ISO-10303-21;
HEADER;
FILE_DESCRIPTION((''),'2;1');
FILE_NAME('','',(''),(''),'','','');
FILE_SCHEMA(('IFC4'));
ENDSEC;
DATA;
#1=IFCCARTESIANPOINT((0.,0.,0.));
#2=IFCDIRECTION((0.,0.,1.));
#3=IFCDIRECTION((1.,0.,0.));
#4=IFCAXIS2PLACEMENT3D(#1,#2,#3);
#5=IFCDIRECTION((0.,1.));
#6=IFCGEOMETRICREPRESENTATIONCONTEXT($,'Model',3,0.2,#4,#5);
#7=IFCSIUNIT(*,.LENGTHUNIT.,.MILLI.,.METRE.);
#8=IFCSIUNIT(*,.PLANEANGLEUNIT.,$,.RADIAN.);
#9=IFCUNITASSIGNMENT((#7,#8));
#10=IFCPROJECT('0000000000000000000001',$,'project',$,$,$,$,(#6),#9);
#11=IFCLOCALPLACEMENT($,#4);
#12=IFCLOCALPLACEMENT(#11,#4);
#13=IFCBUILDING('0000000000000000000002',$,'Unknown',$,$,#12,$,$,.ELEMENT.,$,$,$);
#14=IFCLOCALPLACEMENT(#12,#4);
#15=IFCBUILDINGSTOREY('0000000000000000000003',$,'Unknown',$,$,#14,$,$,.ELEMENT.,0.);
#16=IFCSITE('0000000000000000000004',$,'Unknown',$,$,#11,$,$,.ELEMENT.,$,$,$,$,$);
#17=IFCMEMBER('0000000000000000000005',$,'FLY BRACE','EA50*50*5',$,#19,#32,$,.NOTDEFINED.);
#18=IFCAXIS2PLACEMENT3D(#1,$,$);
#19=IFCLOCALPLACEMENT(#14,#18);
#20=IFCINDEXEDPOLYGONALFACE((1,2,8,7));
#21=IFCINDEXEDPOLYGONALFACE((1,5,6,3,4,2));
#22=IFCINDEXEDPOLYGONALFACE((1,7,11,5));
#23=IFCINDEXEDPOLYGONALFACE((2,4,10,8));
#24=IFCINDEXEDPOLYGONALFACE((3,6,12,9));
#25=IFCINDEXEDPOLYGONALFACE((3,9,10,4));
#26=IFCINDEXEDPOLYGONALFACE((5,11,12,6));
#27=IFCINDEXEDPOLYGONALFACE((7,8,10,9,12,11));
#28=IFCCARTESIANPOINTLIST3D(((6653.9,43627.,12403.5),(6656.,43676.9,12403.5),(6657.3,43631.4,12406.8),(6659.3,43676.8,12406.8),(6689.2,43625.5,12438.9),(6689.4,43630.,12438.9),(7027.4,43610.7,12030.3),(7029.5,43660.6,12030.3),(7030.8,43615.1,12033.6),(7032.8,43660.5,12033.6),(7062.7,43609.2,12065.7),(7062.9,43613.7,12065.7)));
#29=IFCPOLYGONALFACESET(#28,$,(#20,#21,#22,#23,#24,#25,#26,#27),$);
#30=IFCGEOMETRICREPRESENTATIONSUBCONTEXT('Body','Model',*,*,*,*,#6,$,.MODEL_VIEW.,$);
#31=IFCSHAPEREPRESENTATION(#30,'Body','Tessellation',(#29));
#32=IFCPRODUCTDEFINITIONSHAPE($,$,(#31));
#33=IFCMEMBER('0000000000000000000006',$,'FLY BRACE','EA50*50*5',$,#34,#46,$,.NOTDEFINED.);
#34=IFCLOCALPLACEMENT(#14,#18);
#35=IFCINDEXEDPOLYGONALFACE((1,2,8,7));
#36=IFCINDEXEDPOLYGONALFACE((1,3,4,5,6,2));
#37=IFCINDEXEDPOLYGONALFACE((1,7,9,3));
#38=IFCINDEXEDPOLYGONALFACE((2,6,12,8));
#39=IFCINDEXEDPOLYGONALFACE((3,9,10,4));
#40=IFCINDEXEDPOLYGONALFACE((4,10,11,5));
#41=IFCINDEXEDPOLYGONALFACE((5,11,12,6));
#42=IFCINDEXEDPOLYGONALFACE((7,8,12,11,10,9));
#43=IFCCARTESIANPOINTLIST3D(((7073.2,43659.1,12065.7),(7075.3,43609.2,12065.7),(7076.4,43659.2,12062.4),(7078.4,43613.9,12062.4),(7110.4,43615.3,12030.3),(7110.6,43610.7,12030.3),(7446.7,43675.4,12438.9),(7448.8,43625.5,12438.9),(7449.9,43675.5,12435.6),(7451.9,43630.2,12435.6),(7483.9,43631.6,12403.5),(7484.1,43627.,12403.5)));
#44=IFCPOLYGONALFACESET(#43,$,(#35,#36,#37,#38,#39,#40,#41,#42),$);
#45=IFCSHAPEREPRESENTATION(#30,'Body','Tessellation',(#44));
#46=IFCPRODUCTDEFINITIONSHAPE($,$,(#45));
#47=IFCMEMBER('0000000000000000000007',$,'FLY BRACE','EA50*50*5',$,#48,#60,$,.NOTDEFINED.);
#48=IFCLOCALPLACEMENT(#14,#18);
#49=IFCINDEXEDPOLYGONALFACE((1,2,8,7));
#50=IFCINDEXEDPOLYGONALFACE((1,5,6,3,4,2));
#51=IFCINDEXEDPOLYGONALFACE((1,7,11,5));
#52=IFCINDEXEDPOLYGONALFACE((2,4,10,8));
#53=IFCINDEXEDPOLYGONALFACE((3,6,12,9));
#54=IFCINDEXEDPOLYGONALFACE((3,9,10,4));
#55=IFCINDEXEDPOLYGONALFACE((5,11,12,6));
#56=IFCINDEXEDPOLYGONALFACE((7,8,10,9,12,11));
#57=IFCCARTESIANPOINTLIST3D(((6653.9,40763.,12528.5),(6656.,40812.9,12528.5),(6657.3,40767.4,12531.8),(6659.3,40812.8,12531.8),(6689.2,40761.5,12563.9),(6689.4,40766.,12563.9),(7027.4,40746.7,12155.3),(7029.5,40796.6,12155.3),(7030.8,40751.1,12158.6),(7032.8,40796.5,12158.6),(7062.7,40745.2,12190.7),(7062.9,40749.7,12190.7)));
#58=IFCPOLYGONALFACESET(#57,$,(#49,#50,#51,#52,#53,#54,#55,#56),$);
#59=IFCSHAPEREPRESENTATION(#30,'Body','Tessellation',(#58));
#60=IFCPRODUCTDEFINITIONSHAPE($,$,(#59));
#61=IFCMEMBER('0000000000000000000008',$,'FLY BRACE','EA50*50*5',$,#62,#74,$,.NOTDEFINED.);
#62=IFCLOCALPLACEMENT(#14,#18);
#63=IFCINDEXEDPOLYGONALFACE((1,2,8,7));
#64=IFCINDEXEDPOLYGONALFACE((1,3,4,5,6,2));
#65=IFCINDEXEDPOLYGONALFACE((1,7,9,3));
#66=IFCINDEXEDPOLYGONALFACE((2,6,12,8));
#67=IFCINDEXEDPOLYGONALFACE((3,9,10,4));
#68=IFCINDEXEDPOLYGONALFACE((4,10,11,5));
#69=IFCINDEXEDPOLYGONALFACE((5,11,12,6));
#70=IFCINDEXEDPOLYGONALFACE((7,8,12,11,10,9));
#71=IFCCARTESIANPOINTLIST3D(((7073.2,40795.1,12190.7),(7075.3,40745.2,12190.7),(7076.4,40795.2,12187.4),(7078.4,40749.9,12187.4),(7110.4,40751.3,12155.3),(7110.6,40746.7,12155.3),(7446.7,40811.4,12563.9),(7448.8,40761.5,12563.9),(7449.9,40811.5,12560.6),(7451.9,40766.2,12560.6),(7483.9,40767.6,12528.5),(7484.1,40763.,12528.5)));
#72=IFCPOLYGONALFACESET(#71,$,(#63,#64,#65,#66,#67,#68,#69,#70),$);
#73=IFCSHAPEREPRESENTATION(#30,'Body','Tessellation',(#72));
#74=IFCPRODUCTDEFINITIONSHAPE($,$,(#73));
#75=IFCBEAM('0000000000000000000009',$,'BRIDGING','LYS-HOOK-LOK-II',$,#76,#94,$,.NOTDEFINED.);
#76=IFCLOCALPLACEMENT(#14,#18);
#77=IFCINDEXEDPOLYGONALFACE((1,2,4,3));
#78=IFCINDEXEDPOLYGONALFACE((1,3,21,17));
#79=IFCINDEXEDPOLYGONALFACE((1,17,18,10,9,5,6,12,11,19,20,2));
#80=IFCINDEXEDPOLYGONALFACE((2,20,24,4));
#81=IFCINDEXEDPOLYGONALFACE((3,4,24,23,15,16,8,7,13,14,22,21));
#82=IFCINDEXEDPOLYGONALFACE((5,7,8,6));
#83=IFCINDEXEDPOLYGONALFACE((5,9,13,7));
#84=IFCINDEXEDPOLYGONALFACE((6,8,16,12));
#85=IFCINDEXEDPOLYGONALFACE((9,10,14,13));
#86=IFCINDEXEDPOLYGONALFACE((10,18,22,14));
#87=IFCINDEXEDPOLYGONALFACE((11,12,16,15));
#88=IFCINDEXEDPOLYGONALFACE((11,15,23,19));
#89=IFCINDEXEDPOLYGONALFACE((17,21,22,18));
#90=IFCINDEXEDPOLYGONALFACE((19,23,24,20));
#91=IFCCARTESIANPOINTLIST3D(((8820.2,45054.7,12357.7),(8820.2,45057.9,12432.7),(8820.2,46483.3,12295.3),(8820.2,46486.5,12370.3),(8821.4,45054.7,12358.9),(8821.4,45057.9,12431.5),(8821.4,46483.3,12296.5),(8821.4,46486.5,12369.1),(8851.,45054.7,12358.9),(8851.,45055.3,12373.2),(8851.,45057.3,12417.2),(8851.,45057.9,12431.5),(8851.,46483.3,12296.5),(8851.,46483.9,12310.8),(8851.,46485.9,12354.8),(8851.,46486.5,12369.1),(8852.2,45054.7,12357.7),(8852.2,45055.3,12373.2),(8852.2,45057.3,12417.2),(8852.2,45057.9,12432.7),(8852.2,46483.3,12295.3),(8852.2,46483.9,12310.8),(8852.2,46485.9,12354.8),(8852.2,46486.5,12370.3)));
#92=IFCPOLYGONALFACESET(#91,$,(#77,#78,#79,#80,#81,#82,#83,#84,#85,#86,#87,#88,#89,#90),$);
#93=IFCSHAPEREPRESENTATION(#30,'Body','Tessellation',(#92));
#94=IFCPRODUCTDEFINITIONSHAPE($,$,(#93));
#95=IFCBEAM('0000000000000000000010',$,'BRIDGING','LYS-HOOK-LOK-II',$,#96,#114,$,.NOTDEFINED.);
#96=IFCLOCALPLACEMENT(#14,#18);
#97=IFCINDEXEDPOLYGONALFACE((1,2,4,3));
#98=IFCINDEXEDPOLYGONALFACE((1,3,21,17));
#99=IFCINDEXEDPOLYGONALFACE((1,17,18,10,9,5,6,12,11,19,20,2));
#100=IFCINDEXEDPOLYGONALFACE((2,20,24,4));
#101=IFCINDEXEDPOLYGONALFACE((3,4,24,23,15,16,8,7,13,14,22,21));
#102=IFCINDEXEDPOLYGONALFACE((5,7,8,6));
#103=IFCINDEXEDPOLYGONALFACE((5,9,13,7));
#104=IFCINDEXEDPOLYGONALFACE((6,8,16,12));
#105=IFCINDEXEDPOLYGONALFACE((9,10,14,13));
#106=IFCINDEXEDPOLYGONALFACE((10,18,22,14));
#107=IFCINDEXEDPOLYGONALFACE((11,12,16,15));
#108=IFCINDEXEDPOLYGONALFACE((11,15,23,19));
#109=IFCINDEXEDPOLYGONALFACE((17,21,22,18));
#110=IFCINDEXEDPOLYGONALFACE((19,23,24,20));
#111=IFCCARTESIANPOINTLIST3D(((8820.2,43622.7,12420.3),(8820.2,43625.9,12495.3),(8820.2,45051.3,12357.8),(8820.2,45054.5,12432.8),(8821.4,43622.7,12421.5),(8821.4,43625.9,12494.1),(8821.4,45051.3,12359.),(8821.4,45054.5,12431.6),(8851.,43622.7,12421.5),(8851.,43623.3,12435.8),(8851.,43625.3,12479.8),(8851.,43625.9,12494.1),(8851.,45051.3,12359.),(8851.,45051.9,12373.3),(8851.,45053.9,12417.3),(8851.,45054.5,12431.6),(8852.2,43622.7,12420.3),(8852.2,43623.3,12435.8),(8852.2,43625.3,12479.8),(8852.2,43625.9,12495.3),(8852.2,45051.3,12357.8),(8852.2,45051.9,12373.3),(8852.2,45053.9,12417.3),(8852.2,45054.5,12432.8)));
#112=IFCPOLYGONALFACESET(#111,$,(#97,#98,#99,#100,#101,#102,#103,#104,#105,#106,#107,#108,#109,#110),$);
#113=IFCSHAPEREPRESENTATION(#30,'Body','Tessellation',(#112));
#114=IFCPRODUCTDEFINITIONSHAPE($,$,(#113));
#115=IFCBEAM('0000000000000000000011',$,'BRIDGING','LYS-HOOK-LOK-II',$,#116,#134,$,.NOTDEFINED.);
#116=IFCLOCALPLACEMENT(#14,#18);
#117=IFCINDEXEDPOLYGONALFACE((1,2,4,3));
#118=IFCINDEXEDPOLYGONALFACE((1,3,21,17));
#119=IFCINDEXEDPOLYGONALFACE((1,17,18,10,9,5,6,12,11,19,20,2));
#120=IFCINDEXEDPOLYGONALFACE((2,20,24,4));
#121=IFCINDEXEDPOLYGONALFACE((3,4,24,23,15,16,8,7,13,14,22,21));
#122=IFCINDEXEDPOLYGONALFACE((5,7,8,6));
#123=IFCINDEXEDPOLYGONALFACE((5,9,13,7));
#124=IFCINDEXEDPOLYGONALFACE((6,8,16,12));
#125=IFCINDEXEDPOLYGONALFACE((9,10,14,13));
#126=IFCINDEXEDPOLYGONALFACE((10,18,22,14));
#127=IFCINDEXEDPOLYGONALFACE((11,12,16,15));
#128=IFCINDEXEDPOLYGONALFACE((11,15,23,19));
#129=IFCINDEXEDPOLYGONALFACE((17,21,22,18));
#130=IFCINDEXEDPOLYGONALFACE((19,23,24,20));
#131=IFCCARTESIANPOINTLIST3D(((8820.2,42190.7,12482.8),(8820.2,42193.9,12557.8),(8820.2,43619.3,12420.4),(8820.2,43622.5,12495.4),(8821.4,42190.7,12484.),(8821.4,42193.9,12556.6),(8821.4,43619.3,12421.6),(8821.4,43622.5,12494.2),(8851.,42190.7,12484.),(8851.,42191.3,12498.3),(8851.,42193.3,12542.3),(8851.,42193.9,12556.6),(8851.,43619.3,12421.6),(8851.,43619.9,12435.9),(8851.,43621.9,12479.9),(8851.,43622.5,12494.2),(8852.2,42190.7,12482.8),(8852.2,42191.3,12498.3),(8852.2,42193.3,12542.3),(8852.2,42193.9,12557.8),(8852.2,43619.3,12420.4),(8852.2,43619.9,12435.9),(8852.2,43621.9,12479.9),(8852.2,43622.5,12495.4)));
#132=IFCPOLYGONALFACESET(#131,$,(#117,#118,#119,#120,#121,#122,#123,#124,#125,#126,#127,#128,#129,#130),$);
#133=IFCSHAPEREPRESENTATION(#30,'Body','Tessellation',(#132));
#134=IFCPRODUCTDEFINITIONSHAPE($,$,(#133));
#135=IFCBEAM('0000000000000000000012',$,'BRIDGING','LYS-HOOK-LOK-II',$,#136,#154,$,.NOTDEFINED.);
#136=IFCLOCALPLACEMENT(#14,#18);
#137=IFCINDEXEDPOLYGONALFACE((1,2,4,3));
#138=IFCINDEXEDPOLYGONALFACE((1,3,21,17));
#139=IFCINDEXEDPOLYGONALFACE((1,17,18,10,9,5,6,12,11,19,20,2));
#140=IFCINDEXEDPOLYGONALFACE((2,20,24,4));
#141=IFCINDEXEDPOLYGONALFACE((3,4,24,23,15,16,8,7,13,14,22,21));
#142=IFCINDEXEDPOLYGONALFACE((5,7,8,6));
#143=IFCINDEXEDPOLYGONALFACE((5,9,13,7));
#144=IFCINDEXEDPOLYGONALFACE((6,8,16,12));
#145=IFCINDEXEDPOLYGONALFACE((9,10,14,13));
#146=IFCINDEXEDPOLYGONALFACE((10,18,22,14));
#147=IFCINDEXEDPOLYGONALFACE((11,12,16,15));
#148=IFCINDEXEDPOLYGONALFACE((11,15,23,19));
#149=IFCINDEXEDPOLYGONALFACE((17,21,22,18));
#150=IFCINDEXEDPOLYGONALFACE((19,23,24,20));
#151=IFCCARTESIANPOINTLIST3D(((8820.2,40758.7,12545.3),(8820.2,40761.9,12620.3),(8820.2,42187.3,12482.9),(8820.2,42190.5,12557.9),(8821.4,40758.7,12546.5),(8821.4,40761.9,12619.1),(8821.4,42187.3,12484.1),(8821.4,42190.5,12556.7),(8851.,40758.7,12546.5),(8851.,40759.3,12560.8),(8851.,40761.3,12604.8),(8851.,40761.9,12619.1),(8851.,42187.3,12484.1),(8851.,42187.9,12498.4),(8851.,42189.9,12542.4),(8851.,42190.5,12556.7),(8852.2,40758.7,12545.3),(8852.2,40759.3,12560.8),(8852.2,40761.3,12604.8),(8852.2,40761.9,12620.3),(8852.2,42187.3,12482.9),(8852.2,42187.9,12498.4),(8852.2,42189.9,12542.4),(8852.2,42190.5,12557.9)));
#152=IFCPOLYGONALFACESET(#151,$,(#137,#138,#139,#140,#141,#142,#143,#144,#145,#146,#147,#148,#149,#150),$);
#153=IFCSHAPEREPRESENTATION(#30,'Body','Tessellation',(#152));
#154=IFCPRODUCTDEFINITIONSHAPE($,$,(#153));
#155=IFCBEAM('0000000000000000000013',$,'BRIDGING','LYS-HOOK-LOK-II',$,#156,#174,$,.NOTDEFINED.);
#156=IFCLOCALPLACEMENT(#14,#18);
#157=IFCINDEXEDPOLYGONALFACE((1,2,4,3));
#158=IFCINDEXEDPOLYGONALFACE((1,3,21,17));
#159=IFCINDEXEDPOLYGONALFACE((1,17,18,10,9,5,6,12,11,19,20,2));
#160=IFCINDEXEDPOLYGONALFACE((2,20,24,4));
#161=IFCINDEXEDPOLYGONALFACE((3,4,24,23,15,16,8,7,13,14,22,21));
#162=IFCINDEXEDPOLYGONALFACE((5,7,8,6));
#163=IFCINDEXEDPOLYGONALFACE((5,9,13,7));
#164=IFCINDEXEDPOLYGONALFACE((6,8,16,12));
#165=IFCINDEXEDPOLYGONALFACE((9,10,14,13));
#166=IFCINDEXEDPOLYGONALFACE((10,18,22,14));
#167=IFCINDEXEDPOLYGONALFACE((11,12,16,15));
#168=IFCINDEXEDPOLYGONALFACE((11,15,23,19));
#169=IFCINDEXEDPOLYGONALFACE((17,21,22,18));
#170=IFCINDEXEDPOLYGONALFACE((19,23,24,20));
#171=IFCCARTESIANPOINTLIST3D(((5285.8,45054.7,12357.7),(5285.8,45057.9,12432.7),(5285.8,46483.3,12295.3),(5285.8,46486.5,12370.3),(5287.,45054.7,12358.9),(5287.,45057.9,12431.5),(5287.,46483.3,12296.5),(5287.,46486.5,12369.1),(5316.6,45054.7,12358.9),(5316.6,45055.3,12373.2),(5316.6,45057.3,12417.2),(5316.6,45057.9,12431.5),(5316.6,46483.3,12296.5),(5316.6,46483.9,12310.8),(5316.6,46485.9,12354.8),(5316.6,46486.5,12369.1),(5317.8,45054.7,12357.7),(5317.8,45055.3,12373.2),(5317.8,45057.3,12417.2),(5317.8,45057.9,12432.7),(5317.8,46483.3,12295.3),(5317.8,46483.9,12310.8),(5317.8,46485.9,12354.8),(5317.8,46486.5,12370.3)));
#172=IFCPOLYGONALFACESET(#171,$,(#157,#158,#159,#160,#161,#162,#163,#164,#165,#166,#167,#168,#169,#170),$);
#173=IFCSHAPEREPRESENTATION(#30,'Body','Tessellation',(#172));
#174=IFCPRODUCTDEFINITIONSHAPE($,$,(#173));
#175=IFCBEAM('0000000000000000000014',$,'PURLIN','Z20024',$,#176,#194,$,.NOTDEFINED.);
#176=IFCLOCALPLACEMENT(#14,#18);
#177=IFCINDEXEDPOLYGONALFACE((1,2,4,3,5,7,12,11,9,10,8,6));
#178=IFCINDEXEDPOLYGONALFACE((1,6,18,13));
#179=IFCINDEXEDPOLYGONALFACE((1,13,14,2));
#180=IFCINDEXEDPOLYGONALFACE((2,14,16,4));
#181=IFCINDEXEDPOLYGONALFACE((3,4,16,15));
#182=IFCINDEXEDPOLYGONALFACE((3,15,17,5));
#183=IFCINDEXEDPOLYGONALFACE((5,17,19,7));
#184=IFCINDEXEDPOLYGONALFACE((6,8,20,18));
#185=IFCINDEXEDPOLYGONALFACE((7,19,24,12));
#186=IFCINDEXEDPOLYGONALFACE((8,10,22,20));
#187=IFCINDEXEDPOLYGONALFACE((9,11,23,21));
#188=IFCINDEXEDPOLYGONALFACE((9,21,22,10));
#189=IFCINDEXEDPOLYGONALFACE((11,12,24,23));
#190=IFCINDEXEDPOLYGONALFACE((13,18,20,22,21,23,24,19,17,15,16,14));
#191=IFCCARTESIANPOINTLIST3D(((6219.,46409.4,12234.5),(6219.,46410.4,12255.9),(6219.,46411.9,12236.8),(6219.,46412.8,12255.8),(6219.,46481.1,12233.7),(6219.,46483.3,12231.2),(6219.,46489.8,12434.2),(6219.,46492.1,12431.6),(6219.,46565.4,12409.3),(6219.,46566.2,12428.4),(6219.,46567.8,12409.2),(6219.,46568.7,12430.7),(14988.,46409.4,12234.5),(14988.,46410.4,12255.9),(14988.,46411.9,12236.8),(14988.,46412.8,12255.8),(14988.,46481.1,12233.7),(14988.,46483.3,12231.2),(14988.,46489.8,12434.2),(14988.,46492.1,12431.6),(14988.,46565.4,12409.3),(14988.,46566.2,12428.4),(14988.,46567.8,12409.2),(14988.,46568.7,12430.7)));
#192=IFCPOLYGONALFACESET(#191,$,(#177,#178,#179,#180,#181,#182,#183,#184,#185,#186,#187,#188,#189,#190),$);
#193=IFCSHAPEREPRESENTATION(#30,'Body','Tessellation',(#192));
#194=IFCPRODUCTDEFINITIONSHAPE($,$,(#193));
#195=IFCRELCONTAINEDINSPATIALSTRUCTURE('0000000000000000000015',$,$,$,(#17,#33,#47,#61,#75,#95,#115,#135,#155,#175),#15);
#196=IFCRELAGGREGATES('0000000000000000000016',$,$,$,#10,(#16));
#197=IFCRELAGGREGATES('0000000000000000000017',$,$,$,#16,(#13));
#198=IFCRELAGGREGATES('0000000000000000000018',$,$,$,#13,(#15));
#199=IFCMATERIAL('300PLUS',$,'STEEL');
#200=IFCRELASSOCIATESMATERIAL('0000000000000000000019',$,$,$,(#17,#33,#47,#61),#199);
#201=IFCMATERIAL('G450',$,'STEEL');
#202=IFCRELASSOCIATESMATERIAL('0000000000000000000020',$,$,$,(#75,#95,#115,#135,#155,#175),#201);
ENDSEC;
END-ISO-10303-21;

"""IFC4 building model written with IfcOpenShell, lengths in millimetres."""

from ifc_helpers import new_model, si_unit, direction, frame, origin_with_axes, place, context, subcontext, project, spatial, line, indexed_curve, outline, extrude, material, element, save


model = new_model("IFC4")

# Units and contexts
model_context = context("Model", 3, precision=0.2, world=origin_with_axes(), true_north=direction((0.0, 1.0)))
body_context = subcontext(model_context, "Body", "Model", "MODEL_VIEW")
ifc_project = project(units=[si_unit("LENGTHUNIT", "METRE", prefix="MILLI"), si_unit("PLANEANGLEUNIT", "RADIAN")], contexts=[model_context])

# Site, building, storey
site_placement = place(None, origin_with_axes())
site = spatial("IfcSite", under=ifc_project, at=site_placement, Name="Unknown", CompositionType="ELEMENT")
building_placement = place(site_placement, origin_with_axes())
building = spatial("IfcBuilding", under=site, at=building_placement, Name="Unknown", CompositionType="ELEMENT")
storey_placement = place(building_placement, origin_with_axes())
storey = spatial("IfcBuildingStorey", under=building, at=storey_placement, Name="Unknown", CompositionType="ELEMENT", Elevation=0.0)

# Members
ifc_material_1 = material(Name="300PLUS", Category="STEEL")
for number, where, z_axis, x_axis, name in (
    (1, (7046.1, 43634.9, 12048.0), (0.0436, 0.999049, 0.0), (-0.707054, 0.030857, 0.706486), "FLY BRACE"),
    (2, (7091.9, 43634.9, 12048.0), (-0.0436, 0.999049, 0.0), (0.707054, 0.030857, 0.706486), "FLY BRACE"),
    (3, (7046.1, 40770.9, 12173.0), (0.0436, 0.999049, 0.0), (-0.707054, 0.030857, 0.706486), "FLY BRACE"),
    (4, (7091.9, 40770.9, 12173.0), (-0.0436, 0.999049, 0.0), (0.707054, 0.030857, 0.706486), "FLY BRACE"),
):
    element("IfcMember", number, at=place(storey_placement, frame(where, z_axis=z_axis, x_axis=x_axis)), inside=storey, material=ifc_material_1, Name=name, Description="EA50*50*5", PredefinedType="NOTDEFINED", context=body_context, shape_type="SolidModel", body=[
        extrude(outline(indexed_curve([(-25.0, -25.0), (25.0, -25.0), (25.0, -20.4), (-20.4, -20.4), (-20.4, 25.0), (-25.0, 25.0)], segments=[line(1, 2, 3, 4, 5, 6, 1)])), frame((0.0, 0.0, 0.0), z_axis=(-1.0, 0.0, 0.0), x_axis=(0.0, 0.0, 1.0)), (0.0, 0.0, -1.0), 528.2),
    ])

# Beams
ifc_material_2 = material(Name="G450", Category="STEEL")
beam_1_placement = place(storey_placement, frame((8836.2, 45056.3, 12395.2), z_axis=(1.0, 0.0, 0.0), x_axis=(0.0, 0.999047, -0.043638)))
element("IfcBeam", 5, at=beam_1_placement, inside=storey, material=ifc_material_2, Name="BRIDGING", Description="LYS-HOOK-LOK-II", PredefinedType="NOTDEFINED", context=body_context, shape_type="SolidModel", body=[
    extrude(outline(indexed_curve([(16.0, -37.5), (16.0, -22.0), (14.8, -22.0), (14.8, -36.3), (-14.8, -36.3), (-14.8, 36.3), (14.8, 36.3), (14.8, 22.0), (16.0, 22.0), (16.0, 37.5), (-16.0, 37.5), (-16.0, -37.5)], segments=[line(1, 2, 3, 4, 5, 6, 7, 8, 9, 10, 11, 12, 1)])), frame((0.0, 0.0, 0.0), z_axis=(-1.0, 0.0, 0.0), x_axis=(0.0, 0.0, 1.0)), (0.0, 0.0, -1.0), 1430.0),
])
beam_2_placement = place(storey_placement, frame((8836.2, 43624.3, 12457.8), z_axis=(1.0, 0.0, 0.0), x_axis=(0.0, 0.999044, -0.043707)))
element("IfcBeam", 6, at=beam_2_placement, inside=storey, material=ifc_material_2, Name="BRIDGING", Description="LYS-HOOK-LOK-II", PredefinedType="NOTDEFINED", context=body_context, shape_type="SolidModel", body=[
    extrude(outline(indexed_curve([(16.0, -37.5), (16.0, -22.0), (14.8, -22.0), (14.8, -36.3), (-14.8, -36.3), (-14.8, 36.3), (14.8, 36.3), (14.8, 22.0), (16.0, 22.0), (16.0, 37.5), (-16.0, 37.5), (-16.0, -37.5)], segments=[line(1, 2, 3, 4, 5, 6, 7, 8, 9, 10, 11, 12, 1)])), frame((0.0, 0.0, 0.0), z_axis=(-1.0, 0.0, 0.0), x_axis=(0.0, 0.0, 1.0)), (0.0, 0.0, -1.0), 1430.0),
])
for number, where, z_axis, x_axis, name in (
    (7, (8836.2, 42192.3, 12520.3), (1.0, 0.0, 0.0), (0.0, 0.999047, -0.043638), "BRIDGING"),
    (8, (8836.2, 40760.3, 12582.8), (1.0, 0.0, 0.0), (0.0, 0.999047, -0.043638), "BRIDGING"),
    (9, (5301.8, 45056.3, 12395.2), (1.0, 0.0, 0.0), (0.0, 0.999047, -0.043638), "BRIDGING"),
):
    element("IfcBeam", number, at=place(storey_placement, frame(where, z_axis=z_axis, x_axis=x_axis)), inside=storey, material=ifc_material_2, Name=name, Description="LYS-HOOK-LOK-II", PredefinedType="NOTDEFINED", context=body_context, shape_type="SolidModel", body=[
        extrude(outline(indexed_curve([(16.0, -37.5), (16.0, -22.0), (14.8, -22.0), (14.8, -36.3), (-14.8, -36.3), (-14.8, 36.3), (14.8, 36.3), (14.8, 22.0), (16.0, 22.0), (16.0, 37.5), (-16.0, 37.5), (-16.0, -37.5)], segments=[line(1, 2, 3, 4, 5, 6, 7, 8, 9, 10, 11, 12, 1)])), frame((0.0, 0.0, 0.0), z_axis=(-1.0, 0.0, 0.0), x_axis=(0.0, 0.0, 1.0)), (0.0, 0.0, -1.0), 1430.0),
    ])
for number, where, z_axis, x_axis, name in (
    (10, (6219.0, 46486.6, 12332.7), (0.0, -0.999048, 0.043619), (1.0, 0.0, 0.0), "PURLIN"),
):
    element("IfcBeam", number, at=place(storey_placement, frame(where, z_axis=z_axis, x_axis=x_axis)), inside=storey, material=ifc_material_2, Name=name, Description="Z20024", PredefinedType="NOTDEFINED", context=body_context, shape_type="SolidModel", body=[
        extrude(outline(indexed_curve([(72.8, -101.5), (72.8, -80.0), (70.4, -80.0), (70.4, -99.1), (1.2, -99.1), (1.2, 101.5), (-77.8, 101.5), (-77.8, 80.0), (-75.4, 80.0), (-75.4, 99.1), (-1.2, 99.1), (-1.2, -101.5)], segments=[line(1, 2, 3, 4, 5, 6, 7, 8, 9, 10, 11, 12, 1)])), frame((0.0, 0.0, 0.0), z_axis=(-1.0, 0.0, 0.0), x_axis=(0.0, 0.0, 1.0)), (0.0, 0.0, -1.0), 8769.0),
    ])

save(model, "model.ifc")
